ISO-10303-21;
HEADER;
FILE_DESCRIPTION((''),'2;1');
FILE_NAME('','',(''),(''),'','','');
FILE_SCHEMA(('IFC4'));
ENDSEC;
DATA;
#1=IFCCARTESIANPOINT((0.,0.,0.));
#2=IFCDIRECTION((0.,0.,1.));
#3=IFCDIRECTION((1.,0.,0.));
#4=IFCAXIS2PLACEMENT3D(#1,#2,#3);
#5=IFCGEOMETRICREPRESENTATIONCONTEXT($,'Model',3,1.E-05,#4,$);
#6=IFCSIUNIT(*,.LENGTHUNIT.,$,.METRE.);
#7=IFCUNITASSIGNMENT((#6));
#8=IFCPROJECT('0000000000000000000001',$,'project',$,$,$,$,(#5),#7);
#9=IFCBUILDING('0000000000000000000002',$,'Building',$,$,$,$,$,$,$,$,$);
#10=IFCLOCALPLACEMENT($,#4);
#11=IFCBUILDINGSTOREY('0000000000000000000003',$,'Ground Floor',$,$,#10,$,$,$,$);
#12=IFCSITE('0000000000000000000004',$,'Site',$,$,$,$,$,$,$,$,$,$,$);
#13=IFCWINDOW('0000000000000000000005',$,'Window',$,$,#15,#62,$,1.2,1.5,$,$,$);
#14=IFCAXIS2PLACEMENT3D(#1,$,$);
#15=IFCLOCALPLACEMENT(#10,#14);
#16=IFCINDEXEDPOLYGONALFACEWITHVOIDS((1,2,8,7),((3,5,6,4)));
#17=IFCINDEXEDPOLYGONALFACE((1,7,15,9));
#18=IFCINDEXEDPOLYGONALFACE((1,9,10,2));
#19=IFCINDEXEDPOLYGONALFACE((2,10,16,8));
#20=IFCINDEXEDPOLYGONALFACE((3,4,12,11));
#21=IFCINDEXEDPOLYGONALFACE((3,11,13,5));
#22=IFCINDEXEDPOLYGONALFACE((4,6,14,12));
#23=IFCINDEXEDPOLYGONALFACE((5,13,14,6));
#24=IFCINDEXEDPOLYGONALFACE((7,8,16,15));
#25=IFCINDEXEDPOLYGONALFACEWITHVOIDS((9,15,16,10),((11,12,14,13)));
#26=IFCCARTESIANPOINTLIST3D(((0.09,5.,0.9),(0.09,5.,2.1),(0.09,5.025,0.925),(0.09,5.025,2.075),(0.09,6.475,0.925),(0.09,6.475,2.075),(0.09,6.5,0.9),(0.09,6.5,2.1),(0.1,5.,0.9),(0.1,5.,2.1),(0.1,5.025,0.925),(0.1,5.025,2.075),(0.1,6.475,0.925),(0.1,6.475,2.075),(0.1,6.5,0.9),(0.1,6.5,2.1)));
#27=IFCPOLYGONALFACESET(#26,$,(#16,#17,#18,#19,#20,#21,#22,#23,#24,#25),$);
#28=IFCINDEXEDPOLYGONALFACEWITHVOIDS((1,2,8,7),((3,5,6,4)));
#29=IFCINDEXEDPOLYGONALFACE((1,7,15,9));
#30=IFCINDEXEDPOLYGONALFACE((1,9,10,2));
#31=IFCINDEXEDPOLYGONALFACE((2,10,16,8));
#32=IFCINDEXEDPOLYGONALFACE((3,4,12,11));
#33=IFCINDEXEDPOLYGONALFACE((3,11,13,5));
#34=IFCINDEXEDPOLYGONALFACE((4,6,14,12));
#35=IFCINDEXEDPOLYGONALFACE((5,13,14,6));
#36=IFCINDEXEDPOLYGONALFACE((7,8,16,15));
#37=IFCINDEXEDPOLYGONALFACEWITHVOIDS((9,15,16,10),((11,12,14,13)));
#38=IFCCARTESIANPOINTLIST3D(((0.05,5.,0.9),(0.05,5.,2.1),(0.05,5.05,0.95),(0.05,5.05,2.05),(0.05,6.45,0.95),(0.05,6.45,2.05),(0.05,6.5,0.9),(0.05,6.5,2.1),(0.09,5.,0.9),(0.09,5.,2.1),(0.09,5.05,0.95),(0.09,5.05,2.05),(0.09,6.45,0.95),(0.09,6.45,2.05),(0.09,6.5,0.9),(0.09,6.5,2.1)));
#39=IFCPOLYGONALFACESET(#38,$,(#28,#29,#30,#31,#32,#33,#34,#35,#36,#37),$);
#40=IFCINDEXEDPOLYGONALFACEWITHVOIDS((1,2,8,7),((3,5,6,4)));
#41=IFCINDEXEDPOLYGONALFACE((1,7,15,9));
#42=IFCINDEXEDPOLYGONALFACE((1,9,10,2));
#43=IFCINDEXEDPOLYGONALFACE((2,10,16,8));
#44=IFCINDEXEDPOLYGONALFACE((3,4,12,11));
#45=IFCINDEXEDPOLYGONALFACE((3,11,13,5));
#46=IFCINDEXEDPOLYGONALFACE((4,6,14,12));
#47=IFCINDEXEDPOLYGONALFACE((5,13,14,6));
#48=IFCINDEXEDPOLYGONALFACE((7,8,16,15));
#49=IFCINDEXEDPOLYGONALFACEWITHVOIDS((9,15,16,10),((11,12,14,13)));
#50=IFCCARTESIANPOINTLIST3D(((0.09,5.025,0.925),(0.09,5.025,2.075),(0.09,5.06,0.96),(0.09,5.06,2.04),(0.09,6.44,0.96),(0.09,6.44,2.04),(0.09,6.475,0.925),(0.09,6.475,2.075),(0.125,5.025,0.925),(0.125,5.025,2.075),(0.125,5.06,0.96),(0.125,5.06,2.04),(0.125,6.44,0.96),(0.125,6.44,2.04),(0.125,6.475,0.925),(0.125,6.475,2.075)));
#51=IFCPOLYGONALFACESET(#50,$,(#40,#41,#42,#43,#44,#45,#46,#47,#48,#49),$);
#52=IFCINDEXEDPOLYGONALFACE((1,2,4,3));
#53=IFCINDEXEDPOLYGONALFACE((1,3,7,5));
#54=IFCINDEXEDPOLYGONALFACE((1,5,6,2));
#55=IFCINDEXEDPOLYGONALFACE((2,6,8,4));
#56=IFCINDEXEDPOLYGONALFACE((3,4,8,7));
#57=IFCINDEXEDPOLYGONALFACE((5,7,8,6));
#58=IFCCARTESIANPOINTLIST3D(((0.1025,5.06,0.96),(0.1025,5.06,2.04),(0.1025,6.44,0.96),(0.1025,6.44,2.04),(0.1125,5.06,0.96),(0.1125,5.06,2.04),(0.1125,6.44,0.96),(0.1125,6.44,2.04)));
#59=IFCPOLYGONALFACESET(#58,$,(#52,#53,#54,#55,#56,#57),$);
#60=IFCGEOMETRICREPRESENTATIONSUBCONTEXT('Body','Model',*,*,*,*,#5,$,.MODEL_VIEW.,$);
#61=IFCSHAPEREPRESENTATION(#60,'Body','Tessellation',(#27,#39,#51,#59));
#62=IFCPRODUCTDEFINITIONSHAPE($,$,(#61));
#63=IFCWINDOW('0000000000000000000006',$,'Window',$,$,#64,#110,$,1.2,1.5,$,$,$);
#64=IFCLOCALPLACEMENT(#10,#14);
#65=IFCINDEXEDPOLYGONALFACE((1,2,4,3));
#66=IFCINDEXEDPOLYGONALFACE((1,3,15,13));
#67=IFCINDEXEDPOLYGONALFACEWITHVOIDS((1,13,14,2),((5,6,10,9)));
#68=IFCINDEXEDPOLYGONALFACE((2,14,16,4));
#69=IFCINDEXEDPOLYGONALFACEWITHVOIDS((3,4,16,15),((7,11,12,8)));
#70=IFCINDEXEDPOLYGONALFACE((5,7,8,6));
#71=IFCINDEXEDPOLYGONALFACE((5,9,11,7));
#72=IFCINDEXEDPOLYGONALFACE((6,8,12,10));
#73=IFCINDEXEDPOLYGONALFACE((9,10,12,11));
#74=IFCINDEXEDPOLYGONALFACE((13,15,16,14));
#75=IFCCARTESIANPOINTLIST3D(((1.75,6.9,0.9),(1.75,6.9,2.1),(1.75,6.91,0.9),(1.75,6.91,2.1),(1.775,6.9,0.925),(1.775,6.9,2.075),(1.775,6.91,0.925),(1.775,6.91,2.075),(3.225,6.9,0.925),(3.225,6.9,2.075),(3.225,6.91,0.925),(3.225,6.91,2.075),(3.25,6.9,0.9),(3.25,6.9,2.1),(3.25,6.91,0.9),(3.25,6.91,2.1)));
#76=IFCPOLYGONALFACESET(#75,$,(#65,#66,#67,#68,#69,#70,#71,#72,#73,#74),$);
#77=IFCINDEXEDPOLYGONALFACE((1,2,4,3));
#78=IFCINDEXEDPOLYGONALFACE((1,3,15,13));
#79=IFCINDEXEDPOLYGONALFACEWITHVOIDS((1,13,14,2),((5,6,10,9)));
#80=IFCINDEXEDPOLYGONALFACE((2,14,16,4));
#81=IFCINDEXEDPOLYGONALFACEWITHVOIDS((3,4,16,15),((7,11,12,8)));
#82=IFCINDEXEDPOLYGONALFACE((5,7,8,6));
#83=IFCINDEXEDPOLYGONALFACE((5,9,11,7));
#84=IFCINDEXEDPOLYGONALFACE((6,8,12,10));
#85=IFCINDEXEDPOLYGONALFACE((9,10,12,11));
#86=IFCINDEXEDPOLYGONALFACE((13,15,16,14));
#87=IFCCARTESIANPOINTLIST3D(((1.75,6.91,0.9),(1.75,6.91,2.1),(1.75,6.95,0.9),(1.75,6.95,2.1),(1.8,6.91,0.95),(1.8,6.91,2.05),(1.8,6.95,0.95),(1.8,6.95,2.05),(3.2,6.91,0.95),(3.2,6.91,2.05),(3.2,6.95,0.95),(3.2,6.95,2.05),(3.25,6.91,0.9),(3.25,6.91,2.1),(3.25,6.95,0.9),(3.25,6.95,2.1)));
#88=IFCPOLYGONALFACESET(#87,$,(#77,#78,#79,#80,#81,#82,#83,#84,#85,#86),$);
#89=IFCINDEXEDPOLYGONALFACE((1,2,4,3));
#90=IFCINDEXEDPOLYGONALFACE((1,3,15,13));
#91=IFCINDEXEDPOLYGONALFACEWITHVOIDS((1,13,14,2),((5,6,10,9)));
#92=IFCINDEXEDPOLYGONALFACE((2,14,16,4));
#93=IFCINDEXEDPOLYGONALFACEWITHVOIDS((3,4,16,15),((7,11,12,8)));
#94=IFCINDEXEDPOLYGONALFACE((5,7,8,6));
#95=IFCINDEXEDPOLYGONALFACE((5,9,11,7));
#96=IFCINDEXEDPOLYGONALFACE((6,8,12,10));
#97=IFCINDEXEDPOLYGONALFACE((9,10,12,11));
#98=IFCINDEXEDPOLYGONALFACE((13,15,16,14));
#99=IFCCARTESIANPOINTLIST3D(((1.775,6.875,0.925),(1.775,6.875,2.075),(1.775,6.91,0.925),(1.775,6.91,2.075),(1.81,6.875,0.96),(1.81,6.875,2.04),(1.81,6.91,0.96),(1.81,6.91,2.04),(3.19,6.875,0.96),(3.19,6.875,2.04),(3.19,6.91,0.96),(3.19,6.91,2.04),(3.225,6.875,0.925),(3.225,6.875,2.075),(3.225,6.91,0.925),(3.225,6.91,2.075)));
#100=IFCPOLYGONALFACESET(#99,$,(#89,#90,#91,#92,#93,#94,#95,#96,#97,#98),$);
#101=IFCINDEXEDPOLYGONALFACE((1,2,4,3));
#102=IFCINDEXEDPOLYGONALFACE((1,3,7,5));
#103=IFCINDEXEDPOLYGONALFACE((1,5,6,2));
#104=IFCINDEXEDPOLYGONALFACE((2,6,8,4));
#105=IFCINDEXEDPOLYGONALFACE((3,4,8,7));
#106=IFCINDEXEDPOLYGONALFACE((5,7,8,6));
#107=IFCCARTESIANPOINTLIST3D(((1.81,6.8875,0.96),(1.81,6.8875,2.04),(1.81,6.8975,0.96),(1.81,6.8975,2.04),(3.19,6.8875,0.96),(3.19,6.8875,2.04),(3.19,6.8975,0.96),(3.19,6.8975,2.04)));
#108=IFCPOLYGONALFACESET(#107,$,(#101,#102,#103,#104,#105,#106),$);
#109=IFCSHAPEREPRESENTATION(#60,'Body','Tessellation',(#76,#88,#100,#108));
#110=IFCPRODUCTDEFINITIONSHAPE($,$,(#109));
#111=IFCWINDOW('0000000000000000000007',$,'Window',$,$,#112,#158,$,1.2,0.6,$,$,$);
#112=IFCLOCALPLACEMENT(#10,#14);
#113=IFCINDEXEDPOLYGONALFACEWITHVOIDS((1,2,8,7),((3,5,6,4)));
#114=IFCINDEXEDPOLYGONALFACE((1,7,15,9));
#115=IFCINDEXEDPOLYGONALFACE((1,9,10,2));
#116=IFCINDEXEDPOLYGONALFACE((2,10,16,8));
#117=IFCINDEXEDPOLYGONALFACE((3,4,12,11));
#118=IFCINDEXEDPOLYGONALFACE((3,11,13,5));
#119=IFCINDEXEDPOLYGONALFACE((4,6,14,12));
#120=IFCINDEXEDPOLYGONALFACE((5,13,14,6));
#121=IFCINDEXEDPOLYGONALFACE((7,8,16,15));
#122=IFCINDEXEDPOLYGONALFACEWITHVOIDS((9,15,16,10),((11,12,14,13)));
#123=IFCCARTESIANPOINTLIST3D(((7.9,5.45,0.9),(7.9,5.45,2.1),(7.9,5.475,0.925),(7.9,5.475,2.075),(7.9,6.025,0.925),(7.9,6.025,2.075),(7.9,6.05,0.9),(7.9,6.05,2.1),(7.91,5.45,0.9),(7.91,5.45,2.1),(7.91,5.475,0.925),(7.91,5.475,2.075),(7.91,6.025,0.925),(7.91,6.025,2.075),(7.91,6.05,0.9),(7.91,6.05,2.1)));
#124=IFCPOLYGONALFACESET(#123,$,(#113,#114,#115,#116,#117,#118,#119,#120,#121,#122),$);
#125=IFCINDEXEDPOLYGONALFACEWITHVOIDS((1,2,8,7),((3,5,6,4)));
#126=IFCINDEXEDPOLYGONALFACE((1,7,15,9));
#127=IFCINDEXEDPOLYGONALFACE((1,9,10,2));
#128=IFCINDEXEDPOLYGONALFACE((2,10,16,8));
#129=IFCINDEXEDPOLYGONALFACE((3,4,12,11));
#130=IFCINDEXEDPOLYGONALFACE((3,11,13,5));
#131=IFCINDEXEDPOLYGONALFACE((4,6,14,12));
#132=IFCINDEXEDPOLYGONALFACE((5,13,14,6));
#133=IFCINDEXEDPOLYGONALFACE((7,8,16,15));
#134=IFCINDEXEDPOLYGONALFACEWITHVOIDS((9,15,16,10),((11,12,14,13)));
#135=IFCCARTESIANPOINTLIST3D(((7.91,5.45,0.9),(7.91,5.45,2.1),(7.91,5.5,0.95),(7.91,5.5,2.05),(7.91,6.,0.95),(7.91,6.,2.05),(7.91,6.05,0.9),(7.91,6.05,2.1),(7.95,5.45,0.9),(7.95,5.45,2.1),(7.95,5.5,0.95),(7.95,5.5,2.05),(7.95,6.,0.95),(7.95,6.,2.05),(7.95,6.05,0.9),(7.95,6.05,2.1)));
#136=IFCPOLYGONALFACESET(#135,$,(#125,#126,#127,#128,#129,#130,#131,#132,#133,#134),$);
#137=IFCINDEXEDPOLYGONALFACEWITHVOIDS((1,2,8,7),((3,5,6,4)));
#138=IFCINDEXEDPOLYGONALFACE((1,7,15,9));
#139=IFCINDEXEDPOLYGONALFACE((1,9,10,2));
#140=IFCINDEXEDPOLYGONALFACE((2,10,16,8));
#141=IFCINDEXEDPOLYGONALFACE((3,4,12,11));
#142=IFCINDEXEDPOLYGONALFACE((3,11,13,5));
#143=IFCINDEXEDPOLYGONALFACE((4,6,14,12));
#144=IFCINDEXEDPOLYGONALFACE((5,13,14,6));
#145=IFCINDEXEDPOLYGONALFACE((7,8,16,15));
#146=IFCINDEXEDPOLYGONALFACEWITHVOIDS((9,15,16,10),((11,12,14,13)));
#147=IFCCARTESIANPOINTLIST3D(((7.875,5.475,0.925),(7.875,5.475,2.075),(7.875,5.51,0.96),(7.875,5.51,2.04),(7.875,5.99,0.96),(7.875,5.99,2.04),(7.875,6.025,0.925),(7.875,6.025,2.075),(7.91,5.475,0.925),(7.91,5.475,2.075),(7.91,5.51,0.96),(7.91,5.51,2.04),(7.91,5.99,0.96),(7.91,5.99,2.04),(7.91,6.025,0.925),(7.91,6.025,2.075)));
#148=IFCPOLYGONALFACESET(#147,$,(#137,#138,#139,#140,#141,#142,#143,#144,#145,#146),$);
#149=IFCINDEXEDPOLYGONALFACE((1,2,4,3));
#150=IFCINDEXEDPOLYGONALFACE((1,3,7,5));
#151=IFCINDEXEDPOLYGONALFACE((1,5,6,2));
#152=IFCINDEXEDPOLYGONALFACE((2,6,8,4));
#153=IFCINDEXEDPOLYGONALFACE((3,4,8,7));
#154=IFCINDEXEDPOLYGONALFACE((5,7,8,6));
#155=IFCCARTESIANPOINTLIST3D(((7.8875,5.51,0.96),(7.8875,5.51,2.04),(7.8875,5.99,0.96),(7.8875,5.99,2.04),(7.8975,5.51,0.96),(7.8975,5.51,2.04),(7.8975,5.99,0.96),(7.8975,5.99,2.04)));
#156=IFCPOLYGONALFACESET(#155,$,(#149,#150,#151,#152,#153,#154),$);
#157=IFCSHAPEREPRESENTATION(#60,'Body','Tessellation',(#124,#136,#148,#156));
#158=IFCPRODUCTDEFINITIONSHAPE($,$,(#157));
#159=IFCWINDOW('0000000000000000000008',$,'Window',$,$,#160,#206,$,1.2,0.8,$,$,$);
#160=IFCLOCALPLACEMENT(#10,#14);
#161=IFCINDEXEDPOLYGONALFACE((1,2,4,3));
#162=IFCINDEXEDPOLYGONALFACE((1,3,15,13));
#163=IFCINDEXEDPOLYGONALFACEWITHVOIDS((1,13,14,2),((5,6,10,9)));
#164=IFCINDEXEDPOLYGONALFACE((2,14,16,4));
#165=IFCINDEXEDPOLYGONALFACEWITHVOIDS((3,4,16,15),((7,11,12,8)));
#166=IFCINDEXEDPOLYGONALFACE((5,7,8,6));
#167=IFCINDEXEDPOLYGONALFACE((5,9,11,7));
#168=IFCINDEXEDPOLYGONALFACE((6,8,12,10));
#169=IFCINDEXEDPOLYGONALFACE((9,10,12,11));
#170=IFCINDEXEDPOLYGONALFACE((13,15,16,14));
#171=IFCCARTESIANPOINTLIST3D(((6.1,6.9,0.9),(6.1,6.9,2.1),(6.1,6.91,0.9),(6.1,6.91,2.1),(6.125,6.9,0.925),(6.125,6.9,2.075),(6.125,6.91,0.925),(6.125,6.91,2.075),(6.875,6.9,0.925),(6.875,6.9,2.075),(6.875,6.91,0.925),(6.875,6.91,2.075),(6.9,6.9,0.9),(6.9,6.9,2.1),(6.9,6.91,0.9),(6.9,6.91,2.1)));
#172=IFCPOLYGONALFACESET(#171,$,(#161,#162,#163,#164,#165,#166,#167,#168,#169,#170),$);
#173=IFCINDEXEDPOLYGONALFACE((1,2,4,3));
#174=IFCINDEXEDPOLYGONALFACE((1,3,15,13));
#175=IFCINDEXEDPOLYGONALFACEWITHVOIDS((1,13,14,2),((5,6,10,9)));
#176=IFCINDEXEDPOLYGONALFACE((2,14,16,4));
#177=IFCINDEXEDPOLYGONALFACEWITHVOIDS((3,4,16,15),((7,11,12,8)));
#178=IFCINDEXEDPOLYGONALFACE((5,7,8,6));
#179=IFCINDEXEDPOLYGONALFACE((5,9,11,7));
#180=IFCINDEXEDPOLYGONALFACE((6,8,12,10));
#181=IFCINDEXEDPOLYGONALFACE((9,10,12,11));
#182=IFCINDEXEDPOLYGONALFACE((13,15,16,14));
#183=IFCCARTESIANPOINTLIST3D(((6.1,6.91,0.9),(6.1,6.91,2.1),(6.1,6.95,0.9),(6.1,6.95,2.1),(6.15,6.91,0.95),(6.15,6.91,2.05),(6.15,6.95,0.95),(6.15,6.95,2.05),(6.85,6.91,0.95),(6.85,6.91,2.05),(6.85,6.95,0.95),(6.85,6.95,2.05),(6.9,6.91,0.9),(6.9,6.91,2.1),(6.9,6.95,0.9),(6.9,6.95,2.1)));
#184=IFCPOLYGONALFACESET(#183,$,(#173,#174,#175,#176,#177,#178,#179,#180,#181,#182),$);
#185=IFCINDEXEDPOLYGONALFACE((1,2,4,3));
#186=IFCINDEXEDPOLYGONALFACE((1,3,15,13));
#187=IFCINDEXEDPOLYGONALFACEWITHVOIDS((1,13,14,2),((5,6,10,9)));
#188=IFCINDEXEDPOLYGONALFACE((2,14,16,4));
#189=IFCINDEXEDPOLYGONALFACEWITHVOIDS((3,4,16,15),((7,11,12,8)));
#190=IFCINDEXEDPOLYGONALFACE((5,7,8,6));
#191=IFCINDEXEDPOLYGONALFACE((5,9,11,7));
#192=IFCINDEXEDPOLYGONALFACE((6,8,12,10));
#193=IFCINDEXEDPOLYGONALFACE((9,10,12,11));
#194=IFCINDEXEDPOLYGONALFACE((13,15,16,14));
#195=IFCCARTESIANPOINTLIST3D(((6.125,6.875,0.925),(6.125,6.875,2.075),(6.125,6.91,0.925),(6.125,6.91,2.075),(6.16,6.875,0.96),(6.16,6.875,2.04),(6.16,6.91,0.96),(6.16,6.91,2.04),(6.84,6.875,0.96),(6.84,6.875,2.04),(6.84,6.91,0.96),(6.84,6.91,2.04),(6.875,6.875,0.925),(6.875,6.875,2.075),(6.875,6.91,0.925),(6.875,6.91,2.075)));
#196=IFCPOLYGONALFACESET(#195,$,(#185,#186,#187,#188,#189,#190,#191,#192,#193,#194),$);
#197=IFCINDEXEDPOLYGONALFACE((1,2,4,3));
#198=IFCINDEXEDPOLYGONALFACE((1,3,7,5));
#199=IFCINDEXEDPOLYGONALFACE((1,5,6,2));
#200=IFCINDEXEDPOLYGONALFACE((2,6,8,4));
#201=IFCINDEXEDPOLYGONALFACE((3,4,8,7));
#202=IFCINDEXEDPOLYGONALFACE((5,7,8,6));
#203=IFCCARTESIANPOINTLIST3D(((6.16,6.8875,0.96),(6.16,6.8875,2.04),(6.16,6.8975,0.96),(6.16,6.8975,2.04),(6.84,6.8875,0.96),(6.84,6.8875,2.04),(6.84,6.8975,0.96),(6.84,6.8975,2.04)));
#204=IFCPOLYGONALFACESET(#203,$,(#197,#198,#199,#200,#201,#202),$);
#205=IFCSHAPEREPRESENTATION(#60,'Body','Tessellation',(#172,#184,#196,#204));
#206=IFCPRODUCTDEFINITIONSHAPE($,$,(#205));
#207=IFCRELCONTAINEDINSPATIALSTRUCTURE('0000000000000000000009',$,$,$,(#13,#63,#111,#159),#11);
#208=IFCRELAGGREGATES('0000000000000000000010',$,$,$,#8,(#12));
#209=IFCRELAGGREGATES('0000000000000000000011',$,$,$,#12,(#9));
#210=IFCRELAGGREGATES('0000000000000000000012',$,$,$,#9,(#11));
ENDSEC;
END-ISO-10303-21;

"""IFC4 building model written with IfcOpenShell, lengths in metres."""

from ifc_helpers import new_model, si_unit, frame, origin_with_axes, place, context, subcontext, project, spatial, line, indexed_curve, outline, extrude, element, save


model = new_model("IFC4")

# Units and contexts
model_context = context("Model", 3, precision=1e-05, world=origin_with_axes())
body_context = subcontext(model_context, "Body", "Model", "MODEL_VIEW")
ifc_project = project(units=[si_unit("LENGTHUNIT", "METRE")], contexts=[model_context])

# Site, building, storey
site = spatial("IfcSite", under=ifc_project, Name="Site")
building = spatial("IfcBuilding", under=site, Name="Building")
storey_placement = place(None, origin_with_axes())
storey = spatial("IfcBuildingStorey", under=building, at=storey_placement, Name="Ground Floor")

# Windows
for number, where, z_axis, x_axis, name in (
    (1, (0.0, 6.5, 0.9), (0.0, 0.0, 1.0), (0.0, -1.0, 0.0), "Window"),
    (2, (3.25, 7.0, 0.9), (0.0, 0.0, 1.0), (-1.0, 0.0, 0.0), "Window"),
):
    element("IfcWindow", number, at=place(storey_placement, frame(where, z_axis=z_axis, x_axis=x_axis)), inside=storey, Name=name, OverallHeight=1.2, OverallWidth=1.5, context=body_context, shape_type="SweptSolid", body=[
        extrude(outline(indexed_curve([(0.0, 0.0), (1.5, 0.0), (1.5, 1.2), (0.0, 1.2)], segments=[line(1, 2, 3, 4, 1)]), holes=[indexed_curve([(0.025, 0.025), (1.475, 0.025), (1.475, 1.175), (0.025, 1.175)], segments=[line(1, 2, 3, 4, 1)])]), frame((0.0, 0.09, 0.0), z_axis=(0.0, -1.0, 0.0), x_axis=(1.0, 0.0, 0.0)), (0.0, 0.0, -1.0), 0.01),
        extrude(outline(indexed_curve([(0.0, 0.0), (1.5, 0.0), (1.5, 1.2), (0.0, 1.2)], segments=[line(1, 2, 3, 4, 1)]), holes=[indexed_curve([(0.05, 0.05), (1.45, 0.05), (1.45, 1.15), (0.05, 1.15)], segments=[line(1, 2, 3, 4, 1)])]), frame((0.0, 0.05, 0.0), z_axis=(0.0, -1.0, 0.0), x_axis=(1.0, 0.0, 0.0)), (0.0, 0.0, -1.0), 0.04),
        extrude(outline(indexed_curve([(0.0, 0.0), (1.45, 0.0), (1.45, 1.15), (0.0, 1.15)], segments=[line(1, 2, 3, 4, 1)]), holes=[indexed_curve([(0.035, 0.035), (1.415, 0.035), (1.415, 1.115), (0.035, 1.115)], segments=[line(1, 2, 3, 4, 1)])]), frame((0.025, 0.09, 0.025), z_axis=(0.0, -1.0, 0.0), x_axis=(1.0, 0.0, 0.0)), (0.0, 0.0, -1.0), 0.035),
        extrude(outline(indexed_curve([(0.035, 0.035), (1.415, 0.035), (1.415, 1.115), (0.035, 1.115)], segments=[line(1, 2, 3, 4, 1)])), frame((0.025, 0.1025, 0.025), z_axis=(0.0, -1.0, 0.0), x_axis=(1.0, 0.0, 0.0)), (0.0, 0.0, -1.0), 0.01),
    ])
window_1_placement = place(storey_placement, frame((8.0, 5.45, 0.9), z_axis=(0.0, 0.0, 1.0), x_axis=(0.0, 1.0, 0.0)))
element("IfcWindow", 3, at=window_1_placement, inside=storey, Name="Window", OverallHeight=1.2, OverallWidth=0.6, context=body_context, shape_type="SweptSolid", body=[
    extrude(outline(indexed_curve([(0.0, 0.0), (0.6, 0.0), (0.6, 1.2), (0.0, 1.2)], segments=[line(1, 2, 3, 4, 1)]), holes=[indexed_curve([(0.025, 0.025), (0.575, 0.025), (0.575, 1.175), (0.025, 1.175)], segments=[line(1, 2, 3, 4, 1)])]), frame((0.0, 0.09, 0.0), z_axis=(0.0, -1.0, 0.0), x_axis=(1.0, 0.0, 0.0)), (0.0, 0.0, -1.0), 0.01),
    extrude(outline(indexed_curve([(0.0, 0.0), (0.6, 0.0), (0.6, 1.2), (0.0, 1.2)], segments=[line(1, 2, 3, 4, 1)]), holes=[indexed_curve([(0.05, 0.05), (0.55, 0.05), (0.55, 1.15), (0.05, 1.15)], segments=[line(1, 2, 3, 4, 1)])]), frame((0.0, 0.05, 0.0), z_axis=(0.0, -1.0, 0.0), x_axis=(1.0, 0.0, 0.0)), (0.0, 0.0, -1.0), 0.04),
    extrude(outline(indexed_curve([(0.0, 0.0), (0.55, 0.0), (0.55, 1.15), (0.0, 1.15)], segments=[line(1, 2, 3, 4, 1)]), holes=[indexed_curve([(0.035, 0.035), (0.515, 0.035), (0.515, 1.115), (0.035, 1.115)], segments=[line(1, 2, 3, 4, 1)])]), frame((0.025, 0.09, 0.025), z_axis=(0.0, -1.0, 0.0), x_axis=(1.0, 0.0, 0.0)), (0.0, 0.0, -1.0), 0.035),
    extrude(outline(indexed_curve([(0.035, 0.035), (0.515, 0.035), (0.515, 1.115), (0.035, 1.115)], segments=[line(1, 2, 3, 4, 1)])), frame((0.025, 0.1025, 0.025), z_axis=(0.0, -1.0, 0.0), x_axis=(1.0, 0.0, 0.0)), (0.0, 0.0, -1.0), 0.01),
])
window_2_placement = place(storey_placement, frame((6.9, 7.0, 0.9), z_axis=(0.0, 0.0, 1.0), x_axis=(-1.0, 0.0, 0.0)))
element("IfcWindow", 4, at=window_2_placement, inside=storey, Name="Window", OverallHeight=1.2, OverallWidth=0.8, context=body_context, shape_type="SweptSolid", body=[
    extrude(outline(indexed_curve([(0.0, 0.0), (0.8, 0.0), (0.8, 1.2), (0.0, 1.2)], segments=[line(1, 2, 3, 4, 1)]), holes=[indexed_curve([(0.025, 0.025), (0.775, 0.025), (0.775, 1.175), (0.025, 1.175)], segments=[line(1, 2, 3, 4, 1)])]), frame((0.0, 0.09, 0.0), z_axis=(0.0, -1.0, 0.0), x_axis=(1.0, 0.0, 0.0)), (0.0, 0.0, -1.0), 0.01),
    extrude(outline(indexed_curve([(0.0, 0.0), (0.8, 0.0), (0.8, 1.2), (0.0, 1.2)], segments=[line(1, 2, 3, 4, 1)]), holes=[indexed_curve([(0.05, 0.05), (0.75, 0.05), (0.75, 1.15), (0.05, 1.15)], segments=[line(1, 2, 3, 4, 1)])]), frame((0.0, 0.05, 0.0), z_axis=(0.0, -1.0, 0.0), x_axis=(1.0, 0.0, 0.0)), (0.0, 0.0, -1.0), 0.04),
    extrude(outline(indexed_curve([(0.0, 0.0), (0.75, 0.0), (0.75, 1.15), (0.0, 1.15)], segments=[line(1, 2, 3, 4, 1)]), holes=[indexed_curve([(0.035, 0.035), (0.715, 0.035), (0.715, 1.115), (0.035, 1.115)], segments=[line(1, 2, 3, 4, 1)])]), frame((0.025, 0.09, 0.025), z_axis=(0.0, -1.0, 0.0), x_axis=(1.0, 0.0, 0.0)), (0.0, 0.0, -1.0), 0.035),
    extrude(outline(indexed_curve([(0.035, 0.035), (0.715, 0.035), (0.715, 1.115), (0.035, 1.115)], segments=[line(1, 2, 3, 4, 1)])), frame((0.025, 0.1025, 0.025), z_axis=(0.0, -1.0, 0.0), x_axis=(1.0, 0.0, 0.0)), (0.0, 0.0, -1.0), 0.01),
])

save(model, "model.ifc")
